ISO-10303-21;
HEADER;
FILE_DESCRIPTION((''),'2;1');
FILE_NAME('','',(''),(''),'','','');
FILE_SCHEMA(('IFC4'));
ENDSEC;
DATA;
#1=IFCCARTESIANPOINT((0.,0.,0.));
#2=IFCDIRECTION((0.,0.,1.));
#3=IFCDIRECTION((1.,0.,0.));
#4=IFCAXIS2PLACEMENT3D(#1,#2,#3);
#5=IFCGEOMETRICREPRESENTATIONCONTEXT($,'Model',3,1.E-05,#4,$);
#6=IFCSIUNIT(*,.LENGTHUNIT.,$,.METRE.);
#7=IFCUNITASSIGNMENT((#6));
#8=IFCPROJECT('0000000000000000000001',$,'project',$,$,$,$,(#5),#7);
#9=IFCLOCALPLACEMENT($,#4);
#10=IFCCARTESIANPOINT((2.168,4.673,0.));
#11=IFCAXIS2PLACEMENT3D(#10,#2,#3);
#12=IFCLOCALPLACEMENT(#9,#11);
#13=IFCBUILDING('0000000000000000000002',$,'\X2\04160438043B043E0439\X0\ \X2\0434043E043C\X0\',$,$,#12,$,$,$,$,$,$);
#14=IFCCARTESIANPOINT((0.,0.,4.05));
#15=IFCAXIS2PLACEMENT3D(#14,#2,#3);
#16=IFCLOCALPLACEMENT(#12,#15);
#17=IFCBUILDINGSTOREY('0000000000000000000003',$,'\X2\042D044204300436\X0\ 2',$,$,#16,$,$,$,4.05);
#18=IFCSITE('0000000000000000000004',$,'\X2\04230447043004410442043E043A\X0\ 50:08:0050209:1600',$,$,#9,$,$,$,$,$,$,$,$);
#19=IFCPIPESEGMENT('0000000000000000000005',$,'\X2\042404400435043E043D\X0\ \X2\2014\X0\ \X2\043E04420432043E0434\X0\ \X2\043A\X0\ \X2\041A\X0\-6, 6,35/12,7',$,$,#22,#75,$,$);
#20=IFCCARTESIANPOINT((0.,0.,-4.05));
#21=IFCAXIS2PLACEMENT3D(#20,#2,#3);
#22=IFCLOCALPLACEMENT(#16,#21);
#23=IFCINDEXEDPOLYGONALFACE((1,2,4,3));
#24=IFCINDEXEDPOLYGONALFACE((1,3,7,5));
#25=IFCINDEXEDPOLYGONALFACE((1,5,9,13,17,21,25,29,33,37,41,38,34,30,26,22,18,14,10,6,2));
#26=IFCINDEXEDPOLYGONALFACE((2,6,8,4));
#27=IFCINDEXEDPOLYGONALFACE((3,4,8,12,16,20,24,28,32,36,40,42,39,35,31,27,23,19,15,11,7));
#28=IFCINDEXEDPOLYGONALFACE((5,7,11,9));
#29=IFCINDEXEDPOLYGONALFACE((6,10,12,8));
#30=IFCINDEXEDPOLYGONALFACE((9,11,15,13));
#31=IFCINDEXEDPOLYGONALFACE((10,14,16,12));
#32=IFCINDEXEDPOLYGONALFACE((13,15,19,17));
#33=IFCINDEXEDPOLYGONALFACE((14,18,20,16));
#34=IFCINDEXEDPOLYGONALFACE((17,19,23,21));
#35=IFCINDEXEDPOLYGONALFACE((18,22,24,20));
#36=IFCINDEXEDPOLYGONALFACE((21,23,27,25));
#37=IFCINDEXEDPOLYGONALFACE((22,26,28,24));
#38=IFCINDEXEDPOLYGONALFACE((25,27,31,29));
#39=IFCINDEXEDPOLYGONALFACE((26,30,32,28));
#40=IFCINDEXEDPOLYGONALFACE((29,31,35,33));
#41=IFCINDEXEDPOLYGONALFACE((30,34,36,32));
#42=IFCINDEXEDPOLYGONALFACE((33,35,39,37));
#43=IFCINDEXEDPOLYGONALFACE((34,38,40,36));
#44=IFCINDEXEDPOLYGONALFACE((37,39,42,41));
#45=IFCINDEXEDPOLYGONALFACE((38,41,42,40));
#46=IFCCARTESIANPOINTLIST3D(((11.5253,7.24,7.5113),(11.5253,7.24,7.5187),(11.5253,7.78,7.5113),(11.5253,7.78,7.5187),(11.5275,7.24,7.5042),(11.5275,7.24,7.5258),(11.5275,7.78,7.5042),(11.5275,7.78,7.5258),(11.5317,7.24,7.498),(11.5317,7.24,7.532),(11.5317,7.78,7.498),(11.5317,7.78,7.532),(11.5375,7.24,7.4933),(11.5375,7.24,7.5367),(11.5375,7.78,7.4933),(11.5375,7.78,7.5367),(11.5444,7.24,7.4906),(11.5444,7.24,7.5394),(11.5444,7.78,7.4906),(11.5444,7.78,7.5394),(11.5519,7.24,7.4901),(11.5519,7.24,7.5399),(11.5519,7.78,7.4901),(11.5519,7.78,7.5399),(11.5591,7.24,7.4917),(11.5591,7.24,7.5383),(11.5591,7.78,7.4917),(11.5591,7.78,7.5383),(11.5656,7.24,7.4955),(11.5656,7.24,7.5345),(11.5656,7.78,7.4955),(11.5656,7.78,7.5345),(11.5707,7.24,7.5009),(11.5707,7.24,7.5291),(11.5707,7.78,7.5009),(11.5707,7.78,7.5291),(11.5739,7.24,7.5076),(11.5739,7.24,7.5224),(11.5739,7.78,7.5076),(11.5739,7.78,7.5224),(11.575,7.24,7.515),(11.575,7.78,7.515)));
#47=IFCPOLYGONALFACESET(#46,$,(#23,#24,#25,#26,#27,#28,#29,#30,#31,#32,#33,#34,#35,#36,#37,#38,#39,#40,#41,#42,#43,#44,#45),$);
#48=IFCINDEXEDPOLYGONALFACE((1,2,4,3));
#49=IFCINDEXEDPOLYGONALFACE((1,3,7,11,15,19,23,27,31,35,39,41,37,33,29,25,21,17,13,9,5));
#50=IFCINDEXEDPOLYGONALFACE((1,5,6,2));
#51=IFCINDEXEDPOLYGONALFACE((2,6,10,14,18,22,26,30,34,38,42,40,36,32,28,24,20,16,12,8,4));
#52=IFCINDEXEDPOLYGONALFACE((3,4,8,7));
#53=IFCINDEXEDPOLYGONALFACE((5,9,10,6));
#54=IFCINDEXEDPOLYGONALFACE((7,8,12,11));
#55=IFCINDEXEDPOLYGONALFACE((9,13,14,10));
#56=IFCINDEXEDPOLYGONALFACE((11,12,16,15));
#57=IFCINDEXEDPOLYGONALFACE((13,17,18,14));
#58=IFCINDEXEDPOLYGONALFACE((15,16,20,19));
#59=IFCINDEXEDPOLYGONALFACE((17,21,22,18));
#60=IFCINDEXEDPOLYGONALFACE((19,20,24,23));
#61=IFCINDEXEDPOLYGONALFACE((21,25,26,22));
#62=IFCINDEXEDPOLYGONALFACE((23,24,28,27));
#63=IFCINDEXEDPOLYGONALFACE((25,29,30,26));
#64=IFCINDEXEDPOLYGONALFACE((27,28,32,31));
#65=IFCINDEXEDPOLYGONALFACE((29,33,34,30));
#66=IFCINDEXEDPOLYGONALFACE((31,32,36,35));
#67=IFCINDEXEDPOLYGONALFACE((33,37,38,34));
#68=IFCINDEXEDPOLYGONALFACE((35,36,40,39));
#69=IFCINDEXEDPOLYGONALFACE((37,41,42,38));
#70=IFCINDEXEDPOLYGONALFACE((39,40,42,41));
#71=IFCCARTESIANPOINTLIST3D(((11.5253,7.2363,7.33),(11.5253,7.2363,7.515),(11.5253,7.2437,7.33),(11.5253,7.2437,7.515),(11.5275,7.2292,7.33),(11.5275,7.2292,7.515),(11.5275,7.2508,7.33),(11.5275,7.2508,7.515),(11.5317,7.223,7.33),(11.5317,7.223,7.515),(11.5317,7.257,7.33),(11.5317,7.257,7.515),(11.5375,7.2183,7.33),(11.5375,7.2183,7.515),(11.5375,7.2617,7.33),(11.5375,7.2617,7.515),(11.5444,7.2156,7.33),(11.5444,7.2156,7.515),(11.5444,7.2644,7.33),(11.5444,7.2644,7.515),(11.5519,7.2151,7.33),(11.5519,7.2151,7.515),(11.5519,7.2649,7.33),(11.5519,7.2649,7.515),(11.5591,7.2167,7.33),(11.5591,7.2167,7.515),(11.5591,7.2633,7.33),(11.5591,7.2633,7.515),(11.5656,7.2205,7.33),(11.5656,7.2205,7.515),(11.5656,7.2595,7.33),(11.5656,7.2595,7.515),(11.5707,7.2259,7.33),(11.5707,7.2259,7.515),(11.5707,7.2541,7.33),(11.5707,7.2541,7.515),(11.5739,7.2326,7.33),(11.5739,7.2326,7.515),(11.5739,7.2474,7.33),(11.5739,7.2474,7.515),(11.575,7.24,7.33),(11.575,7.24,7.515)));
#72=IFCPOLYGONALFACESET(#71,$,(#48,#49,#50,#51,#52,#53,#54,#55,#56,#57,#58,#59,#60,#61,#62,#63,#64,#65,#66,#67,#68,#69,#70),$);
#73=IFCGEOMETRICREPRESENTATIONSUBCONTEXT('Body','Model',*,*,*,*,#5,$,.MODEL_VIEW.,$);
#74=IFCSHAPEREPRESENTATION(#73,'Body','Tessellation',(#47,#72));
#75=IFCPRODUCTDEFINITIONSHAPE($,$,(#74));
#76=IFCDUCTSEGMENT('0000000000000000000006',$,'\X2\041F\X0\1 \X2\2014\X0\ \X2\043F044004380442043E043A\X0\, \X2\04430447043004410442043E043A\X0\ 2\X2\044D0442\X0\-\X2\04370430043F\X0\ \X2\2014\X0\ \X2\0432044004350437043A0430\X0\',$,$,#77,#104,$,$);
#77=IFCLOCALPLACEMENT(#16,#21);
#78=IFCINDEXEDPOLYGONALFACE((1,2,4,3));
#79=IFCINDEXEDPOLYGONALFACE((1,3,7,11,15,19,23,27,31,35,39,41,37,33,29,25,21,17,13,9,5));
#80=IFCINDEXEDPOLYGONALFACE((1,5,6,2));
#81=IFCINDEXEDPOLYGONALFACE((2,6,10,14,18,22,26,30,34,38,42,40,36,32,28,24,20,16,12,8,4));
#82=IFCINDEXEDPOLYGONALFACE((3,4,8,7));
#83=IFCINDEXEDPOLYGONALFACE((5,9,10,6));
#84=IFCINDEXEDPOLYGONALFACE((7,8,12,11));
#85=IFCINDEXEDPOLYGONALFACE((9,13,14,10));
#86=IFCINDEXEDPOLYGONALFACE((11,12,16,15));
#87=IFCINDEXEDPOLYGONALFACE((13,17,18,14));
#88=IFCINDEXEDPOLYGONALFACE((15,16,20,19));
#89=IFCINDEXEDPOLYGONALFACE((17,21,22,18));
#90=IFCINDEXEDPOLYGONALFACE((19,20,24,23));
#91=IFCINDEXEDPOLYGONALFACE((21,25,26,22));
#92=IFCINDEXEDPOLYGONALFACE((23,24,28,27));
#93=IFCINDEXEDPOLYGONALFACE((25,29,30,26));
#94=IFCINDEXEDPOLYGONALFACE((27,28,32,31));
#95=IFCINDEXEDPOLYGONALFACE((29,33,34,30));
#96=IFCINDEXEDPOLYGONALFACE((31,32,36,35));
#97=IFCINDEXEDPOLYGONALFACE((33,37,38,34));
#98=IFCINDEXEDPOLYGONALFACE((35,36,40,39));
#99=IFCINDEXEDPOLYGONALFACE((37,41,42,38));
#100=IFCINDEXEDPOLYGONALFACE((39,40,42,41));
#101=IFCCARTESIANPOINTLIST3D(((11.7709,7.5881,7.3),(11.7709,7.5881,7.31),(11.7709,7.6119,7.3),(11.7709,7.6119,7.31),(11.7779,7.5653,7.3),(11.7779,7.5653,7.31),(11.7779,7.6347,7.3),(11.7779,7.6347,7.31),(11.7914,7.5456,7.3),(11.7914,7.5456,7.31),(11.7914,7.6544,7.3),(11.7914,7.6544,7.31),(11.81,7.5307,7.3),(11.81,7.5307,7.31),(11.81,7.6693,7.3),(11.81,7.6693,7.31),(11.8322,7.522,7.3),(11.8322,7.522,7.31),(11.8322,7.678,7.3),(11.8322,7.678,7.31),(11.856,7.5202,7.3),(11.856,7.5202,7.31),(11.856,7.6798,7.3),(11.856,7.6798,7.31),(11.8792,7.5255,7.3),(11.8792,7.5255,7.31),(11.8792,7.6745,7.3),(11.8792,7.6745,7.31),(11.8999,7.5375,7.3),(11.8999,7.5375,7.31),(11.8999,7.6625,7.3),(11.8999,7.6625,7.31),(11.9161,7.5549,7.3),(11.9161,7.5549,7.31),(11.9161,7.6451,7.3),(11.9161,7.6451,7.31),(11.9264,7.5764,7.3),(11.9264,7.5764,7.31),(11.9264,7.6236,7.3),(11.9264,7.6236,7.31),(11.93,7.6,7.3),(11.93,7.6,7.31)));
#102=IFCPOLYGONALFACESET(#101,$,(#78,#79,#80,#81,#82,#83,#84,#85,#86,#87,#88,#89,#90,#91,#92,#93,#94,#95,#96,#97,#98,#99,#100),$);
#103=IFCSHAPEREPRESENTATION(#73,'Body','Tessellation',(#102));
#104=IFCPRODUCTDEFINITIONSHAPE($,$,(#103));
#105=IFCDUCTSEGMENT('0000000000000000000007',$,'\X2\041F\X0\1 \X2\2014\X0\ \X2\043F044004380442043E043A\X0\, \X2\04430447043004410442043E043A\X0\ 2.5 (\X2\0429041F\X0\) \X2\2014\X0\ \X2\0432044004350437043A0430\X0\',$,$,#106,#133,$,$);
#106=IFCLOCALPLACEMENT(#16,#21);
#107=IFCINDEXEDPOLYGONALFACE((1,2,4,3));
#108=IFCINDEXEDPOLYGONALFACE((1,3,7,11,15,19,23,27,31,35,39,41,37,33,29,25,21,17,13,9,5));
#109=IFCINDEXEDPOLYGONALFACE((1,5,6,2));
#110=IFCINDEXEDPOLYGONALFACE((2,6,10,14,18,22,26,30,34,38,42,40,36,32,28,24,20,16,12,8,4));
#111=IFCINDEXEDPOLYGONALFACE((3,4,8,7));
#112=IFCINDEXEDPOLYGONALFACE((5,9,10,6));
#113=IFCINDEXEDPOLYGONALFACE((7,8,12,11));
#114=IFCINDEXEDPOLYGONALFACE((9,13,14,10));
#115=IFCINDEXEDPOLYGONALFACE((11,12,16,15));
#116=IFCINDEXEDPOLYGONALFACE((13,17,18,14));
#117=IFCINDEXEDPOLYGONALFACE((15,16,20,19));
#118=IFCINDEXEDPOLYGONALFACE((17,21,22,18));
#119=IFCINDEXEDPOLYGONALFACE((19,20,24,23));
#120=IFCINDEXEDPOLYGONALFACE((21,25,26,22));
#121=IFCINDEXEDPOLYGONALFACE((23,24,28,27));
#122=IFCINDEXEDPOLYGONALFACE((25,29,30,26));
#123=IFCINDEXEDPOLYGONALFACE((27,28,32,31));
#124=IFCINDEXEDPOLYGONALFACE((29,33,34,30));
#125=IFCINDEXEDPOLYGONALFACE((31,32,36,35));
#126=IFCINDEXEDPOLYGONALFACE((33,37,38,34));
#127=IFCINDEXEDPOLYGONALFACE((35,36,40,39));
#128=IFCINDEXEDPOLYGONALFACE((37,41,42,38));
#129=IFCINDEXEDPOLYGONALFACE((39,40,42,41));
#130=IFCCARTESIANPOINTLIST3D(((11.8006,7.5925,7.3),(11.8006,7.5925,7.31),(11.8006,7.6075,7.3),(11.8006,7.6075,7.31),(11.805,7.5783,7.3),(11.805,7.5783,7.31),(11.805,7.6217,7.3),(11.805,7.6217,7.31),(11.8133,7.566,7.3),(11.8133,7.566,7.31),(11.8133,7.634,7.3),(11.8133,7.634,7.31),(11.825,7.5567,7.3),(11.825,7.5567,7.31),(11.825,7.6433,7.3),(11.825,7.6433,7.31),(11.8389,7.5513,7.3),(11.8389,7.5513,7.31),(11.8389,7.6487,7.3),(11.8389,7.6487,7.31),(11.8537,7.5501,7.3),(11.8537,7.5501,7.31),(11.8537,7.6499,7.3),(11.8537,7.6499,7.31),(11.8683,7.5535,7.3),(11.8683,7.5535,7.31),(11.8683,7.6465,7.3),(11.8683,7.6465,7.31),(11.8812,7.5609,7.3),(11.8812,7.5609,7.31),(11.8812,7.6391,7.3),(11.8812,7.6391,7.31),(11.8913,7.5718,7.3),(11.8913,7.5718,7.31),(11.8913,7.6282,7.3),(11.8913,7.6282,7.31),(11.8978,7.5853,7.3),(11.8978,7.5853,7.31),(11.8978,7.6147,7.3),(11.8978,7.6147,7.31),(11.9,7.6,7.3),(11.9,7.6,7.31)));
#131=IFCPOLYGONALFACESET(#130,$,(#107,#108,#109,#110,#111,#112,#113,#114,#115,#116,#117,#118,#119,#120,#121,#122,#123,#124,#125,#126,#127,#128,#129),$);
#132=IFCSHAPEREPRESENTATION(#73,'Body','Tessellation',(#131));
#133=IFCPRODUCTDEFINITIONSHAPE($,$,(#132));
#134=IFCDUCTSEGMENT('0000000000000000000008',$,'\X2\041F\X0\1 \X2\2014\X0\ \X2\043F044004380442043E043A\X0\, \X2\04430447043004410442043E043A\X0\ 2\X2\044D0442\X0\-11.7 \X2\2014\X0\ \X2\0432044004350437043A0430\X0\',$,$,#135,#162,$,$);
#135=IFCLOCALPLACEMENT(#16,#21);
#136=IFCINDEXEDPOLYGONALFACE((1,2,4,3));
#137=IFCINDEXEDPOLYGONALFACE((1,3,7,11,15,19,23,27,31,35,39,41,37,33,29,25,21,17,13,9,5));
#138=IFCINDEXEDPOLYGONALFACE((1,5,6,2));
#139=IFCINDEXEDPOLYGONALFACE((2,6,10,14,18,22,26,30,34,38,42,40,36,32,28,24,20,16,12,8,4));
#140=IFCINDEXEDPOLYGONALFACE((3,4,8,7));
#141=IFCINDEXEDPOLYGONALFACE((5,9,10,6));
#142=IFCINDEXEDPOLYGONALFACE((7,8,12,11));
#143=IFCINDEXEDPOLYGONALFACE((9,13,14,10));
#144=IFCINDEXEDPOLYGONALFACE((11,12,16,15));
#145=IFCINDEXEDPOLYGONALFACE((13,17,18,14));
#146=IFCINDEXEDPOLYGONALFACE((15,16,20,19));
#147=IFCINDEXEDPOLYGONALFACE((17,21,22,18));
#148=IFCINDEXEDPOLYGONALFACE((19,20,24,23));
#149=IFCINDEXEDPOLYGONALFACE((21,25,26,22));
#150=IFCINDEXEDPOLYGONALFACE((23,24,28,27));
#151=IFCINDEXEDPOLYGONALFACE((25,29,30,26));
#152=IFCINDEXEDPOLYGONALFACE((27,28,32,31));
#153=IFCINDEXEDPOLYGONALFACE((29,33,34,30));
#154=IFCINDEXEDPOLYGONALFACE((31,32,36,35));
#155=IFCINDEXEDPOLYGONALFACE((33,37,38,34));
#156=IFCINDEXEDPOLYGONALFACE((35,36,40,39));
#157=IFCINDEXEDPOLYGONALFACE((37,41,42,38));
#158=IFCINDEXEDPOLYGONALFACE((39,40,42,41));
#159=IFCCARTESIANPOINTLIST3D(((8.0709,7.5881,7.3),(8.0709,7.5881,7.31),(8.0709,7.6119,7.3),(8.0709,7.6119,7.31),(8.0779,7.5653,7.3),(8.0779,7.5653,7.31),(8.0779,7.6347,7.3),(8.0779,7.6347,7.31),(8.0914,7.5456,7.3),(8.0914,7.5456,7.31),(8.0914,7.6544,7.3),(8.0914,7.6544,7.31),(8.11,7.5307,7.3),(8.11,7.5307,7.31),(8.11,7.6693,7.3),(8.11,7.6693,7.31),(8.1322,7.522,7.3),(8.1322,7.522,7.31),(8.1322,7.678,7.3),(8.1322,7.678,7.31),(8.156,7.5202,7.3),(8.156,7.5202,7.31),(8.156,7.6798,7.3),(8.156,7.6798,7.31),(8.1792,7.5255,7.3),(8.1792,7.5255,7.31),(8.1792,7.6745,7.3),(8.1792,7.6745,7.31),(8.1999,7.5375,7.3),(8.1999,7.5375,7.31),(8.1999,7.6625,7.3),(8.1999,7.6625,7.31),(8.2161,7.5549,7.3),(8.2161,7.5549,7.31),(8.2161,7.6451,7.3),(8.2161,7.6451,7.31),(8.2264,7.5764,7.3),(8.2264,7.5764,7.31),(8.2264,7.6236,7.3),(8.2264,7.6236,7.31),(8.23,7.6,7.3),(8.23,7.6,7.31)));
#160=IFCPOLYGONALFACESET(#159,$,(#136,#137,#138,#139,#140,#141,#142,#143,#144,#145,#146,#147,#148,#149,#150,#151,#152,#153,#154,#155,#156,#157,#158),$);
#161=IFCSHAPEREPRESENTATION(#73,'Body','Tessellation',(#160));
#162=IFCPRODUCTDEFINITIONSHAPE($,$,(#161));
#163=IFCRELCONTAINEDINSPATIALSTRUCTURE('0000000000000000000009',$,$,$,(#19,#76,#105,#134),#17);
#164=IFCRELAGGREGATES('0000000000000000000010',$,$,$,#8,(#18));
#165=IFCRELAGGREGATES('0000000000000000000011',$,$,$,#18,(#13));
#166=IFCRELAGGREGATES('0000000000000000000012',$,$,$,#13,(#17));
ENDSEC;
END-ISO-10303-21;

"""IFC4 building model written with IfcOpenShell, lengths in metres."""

from ifc_helpers import new_model, si_unit, frame, origin_with_axes, origin_2d, place, context, subcontext, project, spatial, circle, extrude, element, save


model = new_model("IFC4")

# Units and contexts
model_context = context("Model", 3, precision=1e-05, world=origin_with_axes())
body_context = subcontext(model_context, "Body", "Model", "MODEL_VIEW")
ifc_project = project(units=[si_unit("LENGTHUNIT", "METRE")], contexts=[model_context])

# Site, building, storey
site_placement = place(None, origin_with_axes())
site = spatial("IfcSite", under=ifc_project, at=site_placement, Name="Участок 50:08:0050209:1600")
building_placement = place(site_placement, frame((2.168, 4.673, 0.0), z_axis=(0.0, 0.0, 1.0), x_axis=(1.0, 0.0, 0.0)))
building = spatial("IfcBuilding", under=site, at=building_placement, Name="Жилой дом")
storey_placement = place(building_placement, frame((0.0, 0.0, 4.05), z_axis=(0.0, 0.0, 1.0), x_axis=(1.0, 0.0, 0.0)))
storey = spatial("IfcBuildingStorey", under=building, at=storey_placement, Name="Этаж 2", Elevation=4.05)

# Pipe segment
pipe_segment_1_placement = place(storey_placement, frame((0.0, 0.0, -4.05), z_axis=(0.0, 0.0, 1.0), x_axis=(1.0, 0.0, 0.0)))
element("IfcPipeSegment", 1, at=pipe_segment_1_placement, inside=storey, Name="Фреон — отвод к К-6, 6,35/12,7", context=body_context, shape_type="SweptSolid", body=[
    extrude(circle(Radius=0.025, at=origin_2d()), frame((11.55, 7.78, 7.515), z_axis=(0.0, -1.0, 0.0), x_axis=(1.0, 0.0, 0.0)), (0.0, 0.0, 1.0), 0.54),
    extrude(circle(Radius=0.025, at=origin_2d()), frame((11.55, 7.24, 7.515), z_axis=(0.0, 0.0, -1.0), x_axis=(1.0, 0.0, 0.0)), (0.0, 0.0, 1.0), 0.185),
])

# Duct segments
duct_segment_1_placement = place(storey_placement, frame((0.0, 0.0, -4.05), z_axis=(0.0, 0.0, 1.0), x_axis=(1.0, 0.0, 0.0)))
element("IfcDuctSegment", 2, at=duct_segment_1_placement, inside=storey, Name="П1 — приток, участок 2эт-зап — врезка", context=body_context, shape_type="SweptSolid", body=[
    extrude(circle(Radius=0.08, at=origin_2d()), frame((11.85, 7.6, 7.31), z_axis=(0.0, 0.0, -1.0), x_axis=(1.0, 0.0, 0.0)), (0.0, 0.0, 1.0), 0.01),
])
duct_segment_2_placement = place(storey_placement, frame((0.0, 0.0, -4.05), z_axis=(0.0, 0.0, 1.0), x_axis=(1.0, 0.0, 0.0)))
element("IfcDuctSegment", 3, at=duct_segment_2_placement, inside=storey, Name="П1 — приток, участок 2.5 (ЩП) — врезка", context=body_context, shape_type="SweptSolid", body=[
    extrude(circle(Radius=0.05, at=origin_2d()), frame((11.85, 7.6, 7.3), z_axis=(0.0, 0.0, 1.0), x_axis=(1.0, 0.0, 0.0)), (0.0, 0.0, 1.0), 0.01),
])
duct_segment_3_placement = place(storey_placement, frame((0.0, 0.0, -4.05), z_axis=(0.0, 0.0, 1.0), x_axis=(1.0, 0.0, 0.0)))
element("IfcDuctSegment", 4, at=duct_segment_3_placement, inside=storey, Name="П1 — приток, участок 2эт-11.7 — врезка", context=body_context, shape_type="SweptSolid", body=[
    extrude(circle(Radius=0.08, at=origin_2d()), frame((8.15, 7.6, 7.31), z_axis=(0.0, 0.0, -1.0), x_axis=(1.0, 0.0, 0.0)), (0.0, 0.0, 1.0), 0.01),
])

save(model, "model.ifc")
